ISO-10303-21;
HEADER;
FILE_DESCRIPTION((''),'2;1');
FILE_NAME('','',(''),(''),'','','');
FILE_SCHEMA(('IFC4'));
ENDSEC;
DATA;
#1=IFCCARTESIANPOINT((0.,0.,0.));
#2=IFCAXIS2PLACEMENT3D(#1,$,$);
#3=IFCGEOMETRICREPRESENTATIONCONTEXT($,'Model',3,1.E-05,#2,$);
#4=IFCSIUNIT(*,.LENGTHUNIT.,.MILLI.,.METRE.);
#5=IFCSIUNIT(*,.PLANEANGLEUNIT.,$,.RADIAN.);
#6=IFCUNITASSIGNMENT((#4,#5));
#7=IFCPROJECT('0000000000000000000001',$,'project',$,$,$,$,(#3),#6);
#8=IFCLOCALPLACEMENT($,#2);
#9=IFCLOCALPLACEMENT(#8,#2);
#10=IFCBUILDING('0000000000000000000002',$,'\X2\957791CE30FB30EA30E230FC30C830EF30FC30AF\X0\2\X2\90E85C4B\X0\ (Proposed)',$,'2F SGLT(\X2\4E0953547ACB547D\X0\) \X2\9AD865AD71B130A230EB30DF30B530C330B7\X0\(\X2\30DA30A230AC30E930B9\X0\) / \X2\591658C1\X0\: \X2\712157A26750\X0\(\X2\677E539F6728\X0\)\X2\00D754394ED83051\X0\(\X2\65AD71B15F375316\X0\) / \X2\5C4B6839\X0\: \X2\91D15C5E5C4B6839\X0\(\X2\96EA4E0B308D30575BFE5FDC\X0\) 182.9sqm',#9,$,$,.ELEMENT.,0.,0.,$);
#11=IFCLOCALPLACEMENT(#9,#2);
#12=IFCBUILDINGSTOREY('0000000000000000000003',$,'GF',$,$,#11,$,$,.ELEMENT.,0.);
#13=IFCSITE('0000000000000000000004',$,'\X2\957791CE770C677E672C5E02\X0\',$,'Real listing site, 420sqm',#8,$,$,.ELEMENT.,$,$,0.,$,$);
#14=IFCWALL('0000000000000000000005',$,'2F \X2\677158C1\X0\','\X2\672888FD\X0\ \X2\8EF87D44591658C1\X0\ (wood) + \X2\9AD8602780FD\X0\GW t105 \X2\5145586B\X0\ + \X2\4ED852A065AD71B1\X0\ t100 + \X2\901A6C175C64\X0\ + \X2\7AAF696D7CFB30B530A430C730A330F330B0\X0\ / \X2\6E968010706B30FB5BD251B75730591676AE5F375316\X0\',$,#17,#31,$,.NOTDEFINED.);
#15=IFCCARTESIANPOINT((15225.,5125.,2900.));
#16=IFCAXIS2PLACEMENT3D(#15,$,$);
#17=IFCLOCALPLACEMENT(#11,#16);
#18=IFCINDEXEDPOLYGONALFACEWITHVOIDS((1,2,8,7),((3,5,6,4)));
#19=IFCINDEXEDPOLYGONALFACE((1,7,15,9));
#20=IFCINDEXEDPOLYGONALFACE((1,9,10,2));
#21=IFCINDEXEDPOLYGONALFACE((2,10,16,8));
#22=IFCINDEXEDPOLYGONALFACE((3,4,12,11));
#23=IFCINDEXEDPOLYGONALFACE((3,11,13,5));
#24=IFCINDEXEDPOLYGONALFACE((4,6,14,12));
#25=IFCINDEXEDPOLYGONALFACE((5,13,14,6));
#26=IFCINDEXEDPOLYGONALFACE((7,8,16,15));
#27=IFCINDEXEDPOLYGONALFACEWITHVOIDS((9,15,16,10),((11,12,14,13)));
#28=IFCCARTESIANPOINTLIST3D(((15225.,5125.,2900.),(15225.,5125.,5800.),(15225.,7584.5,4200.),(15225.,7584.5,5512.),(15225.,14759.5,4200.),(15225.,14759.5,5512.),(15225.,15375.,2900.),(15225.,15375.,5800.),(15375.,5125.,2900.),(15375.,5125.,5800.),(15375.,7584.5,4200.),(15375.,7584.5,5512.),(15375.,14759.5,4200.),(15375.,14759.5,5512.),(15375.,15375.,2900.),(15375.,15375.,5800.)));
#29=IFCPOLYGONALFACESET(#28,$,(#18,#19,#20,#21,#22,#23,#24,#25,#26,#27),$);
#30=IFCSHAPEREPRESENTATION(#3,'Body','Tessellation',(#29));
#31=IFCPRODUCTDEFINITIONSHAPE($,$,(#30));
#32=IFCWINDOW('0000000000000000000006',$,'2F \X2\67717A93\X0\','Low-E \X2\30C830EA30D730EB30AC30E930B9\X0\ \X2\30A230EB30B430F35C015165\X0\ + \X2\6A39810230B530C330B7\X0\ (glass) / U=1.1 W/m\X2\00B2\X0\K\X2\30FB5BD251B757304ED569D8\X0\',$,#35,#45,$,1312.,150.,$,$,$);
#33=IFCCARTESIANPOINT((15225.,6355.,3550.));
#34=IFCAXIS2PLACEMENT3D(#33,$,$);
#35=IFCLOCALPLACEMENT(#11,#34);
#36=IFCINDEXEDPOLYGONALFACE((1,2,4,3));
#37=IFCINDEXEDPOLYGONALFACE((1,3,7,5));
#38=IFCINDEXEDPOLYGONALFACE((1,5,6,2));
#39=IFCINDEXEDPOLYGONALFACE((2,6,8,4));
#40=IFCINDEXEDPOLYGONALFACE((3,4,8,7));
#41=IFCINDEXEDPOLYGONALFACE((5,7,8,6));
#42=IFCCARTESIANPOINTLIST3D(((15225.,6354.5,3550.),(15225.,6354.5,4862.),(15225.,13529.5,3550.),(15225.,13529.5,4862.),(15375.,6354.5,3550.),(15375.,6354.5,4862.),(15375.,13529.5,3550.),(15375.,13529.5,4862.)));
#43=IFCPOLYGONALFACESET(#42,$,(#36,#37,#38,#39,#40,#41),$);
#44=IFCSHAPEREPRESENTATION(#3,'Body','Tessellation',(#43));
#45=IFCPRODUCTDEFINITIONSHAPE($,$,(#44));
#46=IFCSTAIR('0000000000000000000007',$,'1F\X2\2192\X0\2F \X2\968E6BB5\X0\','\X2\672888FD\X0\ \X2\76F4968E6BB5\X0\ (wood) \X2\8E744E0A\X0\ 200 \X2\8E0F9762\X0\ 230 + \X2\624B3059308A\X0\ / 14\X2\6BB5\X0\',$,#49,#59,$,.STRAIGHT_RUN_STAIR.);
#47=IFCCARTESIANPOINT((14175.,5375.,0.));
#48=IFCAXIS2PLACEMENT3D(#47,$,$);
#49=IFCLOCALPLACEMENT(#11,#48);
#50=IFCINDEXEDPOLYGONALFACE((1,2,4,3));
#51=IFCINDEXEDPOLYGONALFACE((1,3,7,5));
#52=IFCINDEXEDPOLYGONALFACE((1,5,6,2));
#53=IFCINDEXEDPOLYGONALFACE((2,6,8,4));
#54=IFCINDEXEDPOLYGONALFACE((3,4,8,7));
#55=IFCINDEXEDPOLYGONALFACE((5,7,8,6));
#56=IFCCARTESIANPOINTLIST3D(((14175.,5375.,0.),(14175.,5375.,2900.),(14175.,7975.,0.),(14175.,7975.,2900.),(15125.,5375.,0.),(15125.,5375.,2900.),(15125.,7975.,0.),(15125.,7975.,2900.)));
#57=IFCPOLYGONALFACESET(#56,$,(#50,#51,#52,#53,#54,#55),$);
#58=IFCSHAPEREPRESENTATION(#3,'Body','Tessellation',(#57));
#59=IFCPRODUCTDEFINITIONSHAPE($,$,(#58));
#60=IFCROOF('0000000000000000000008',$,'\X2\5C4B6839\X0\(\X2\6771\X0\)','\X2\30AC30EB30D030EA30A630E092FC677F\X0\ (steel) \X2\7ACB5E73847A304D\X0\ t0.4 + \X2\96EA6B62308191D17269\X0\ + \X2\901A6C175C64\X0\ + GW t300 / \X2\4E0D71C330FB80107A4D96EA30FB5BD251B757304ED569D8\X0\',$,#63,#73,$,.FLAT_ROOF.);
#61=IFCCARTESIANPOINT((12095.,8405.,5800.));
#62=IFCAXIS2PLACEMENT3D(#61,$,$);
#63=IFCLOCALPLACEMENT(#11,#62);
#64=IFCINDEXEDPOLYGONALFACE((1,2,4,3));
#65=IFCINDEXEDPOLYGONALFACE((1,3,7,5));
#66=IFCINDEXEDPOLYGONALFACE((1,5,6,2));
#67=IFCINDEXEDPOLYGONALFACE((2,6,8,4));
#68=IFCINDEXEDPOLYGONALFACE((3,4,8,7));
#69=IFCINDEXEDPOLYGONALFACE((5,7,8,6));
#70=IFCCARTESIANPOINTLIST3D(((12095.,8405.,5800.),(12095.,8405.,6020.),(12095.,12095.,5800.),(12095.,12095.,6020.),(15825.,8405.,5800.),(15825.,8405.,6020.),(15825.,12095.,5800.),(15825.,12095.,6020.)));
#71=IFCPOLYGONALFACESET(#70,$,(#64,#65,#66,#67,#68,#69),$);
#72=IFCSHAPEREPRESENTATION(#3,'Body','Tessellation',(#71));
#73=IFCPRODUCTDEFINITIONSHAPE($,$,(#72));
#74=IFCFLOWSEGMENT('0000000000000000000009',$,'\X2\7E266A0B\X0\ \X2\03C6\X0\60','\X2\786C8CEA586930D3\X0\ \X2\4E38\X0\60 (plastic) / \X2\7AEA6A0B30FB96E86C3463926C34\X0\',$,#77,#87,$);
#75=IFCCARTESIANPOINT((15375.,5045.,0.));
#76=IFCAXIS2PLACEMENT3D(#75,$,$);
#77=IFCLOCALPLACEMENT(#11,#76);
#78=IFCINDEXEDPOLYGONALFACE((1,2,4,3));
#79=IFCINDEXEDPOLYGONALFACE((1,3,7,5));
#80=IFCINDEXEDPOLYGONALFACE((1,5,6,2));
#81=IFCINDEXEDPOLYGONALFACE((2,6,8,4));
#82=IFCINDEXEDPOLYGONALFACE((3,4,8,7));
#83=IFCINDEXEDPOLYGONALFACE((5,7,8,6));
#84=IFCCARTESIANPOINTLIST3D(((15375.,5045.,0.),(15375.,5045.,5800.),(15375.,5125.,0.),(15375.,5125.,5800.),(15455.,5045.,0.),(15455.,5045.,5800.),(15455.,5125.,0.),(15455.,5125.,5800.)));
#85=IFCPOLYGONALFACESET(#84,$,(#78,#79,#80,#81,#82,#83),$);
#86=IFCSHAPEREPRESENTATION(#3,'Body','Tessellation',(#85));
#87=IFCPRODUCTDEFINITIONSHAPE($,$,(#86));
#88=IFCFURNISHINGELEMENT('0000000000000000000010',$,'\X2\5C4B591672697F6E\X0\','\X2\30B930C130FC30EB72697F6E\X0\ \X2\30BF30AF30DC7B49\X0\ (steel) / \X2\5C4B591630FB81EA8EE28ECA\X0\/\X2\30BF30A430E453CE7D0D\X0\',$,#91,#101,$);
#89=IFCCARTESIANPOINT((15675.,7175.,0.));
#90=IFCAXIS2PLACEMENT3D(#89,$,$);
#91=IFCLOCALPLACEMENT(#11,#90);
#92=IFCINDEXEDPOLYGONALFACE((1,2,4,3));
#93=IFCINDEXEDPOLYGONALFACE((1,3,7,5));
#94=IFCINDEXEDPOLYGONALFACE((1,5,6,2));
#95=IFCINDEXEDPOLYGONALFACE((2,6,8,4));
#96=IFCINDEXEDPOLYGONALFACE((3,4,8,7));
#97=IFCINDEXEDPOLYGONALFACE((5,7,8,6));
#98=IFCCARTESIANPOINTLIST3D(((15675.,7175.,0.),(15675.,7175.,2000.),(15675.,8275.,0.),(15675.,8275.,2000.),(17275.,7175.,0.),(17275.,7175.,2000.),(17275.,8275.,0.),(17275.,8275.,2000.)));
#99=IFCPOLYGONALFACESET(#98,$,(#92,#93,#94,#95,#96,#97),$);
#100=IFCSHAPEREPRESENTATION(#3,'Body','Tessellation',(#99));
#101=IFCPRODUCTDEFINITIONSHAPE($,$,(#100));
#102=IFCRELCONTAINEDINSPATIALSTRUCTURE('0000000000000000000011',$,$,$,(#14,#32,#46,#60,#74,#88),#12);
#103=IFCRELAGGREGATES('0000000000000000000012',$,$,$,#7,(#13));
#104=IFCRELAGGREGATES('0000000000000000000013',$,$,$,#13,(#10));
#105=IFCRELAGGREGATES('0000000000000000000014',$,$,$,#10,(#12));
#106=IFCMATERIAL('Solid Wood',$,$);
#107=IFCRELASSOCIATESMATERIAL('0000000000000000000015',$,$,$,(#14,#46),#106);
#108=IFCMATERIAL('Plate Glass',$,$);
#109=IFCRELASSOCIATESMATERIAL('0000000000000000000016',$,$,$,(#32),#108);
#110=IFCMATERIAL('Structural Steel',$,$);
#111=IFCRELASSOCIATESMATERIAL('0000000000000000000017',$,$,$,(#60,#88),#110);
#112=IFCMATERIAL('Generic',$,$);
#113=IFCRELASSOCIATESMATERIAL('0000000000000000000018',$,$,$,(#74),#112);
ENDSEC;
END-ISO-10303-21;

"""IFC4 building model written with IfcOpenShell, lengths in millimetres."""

from ifc_helpers import new_model, si_unit, frame, frame_2d, origin, place, context, project, spatial, rectangle, extrude, material, element, fill, save


model = new_model("IFC4")

# Units and contexts
model_context = context("Model", 3, precision=1e-05, world=origin())
ifc_project = project(units=[si_unit("LENGTHUNIT", "METRE", prefix="MILLI"), si_unit("PLANEANGLEUNIT", "RADIAN")], contexts=[model_context])

# Site, building, storey
site_placement = place(None, origin())
site = spatial("IfcSite", under=ifc_project, at=site_placement, Name="長野県松本市", ObjectType="Real listing site, 420sqm", CompositionType="ELEMENT", RefElevation=0.0)
building_placement = place(site_placement, origin())
building = spatial("IfcBuilding", under=site, at=building_placement, Name="長野・リモートワーク2部屋 (Proposed)", ObjectType="2F SGLT(三協立命) 高断熱アルミサッシ(ペアガラス) / 外壁: 無垢材(松原木)×吹付け(断熱強化) / 屋根: 金属屋根(雪下ろし対応) 182.9sqm", CompositionType="ELEMENT", ElevationOfRefHeight=0.0, ElevationOfTerrain=0.0)
storey_placement = place(building_placement, origin())
storey = spatial("IfcBuildingStorey", under=building, at=storey_placement, Name="GF", CompositionType="ELEMENT", Elevation=0.0)

# Shared definitions
ifc_material_1 = material(Name="Solid Wood")

# Wall, opening, window
ifc_material_2 = material(Name="Plate Glass")
wall_1_placement = place(storey_placement, frame((15225.0, 5125.0, 2900.0)))
wall_1 = element("IfcWall", 1, at=wall_1_placement, inside=storey, material=ifc_material_1, Name="2F 東壁", Description="木製 軸組外壁 (wood) + 高性能GW t105 充填 + 付加断熱 t100 + 通気層 + 窯業系サイディング / 準耐火・寒冷地外皮強化", PredefinedType="NOTDEFINED", context=model_context, shape_type="SweptSolid", body=[
    extrude(rectangle(XDim=150.0, YDim=10250.0, at=frame_2d((75.0, 5125.0))), frame((15225.0, 5125.0, 2900.0)), (0.0, 0.0, 1.0), 2900.0),
])
opening_1_placement = place(storey_placement, frame((15225.0, 6355.0, 3550.0)))
opening_1 = element("IfcOpeningElement", 2, at=opening_1_placement, cuts=wall_1, PredefinedType="NOTDEFINED", context=model_context, shape_type="SweptSolid", body=[
    extrude(rectangle(XDim=150.0, YDim=7175.0, at=frame_2d((75.0, 3587.0))), frame((15225.0, 6355.0, 3550.0)), (0.0, 0.0, 1.0), 1312.0),
])
window_1_placement = place(storey_placement, frame((15225.0, 6355.0, 3550.0)))
window_1 = element("IfcWindow", 3, at=window_1_placement, inside=storey, material=ifc_material_2, Name="2F 東窓", Description="Low-E トリプルガラス アルゴン封入 + 樹脂サッシ (glass) / U=1.1 W/m²K・寒冷地仕様", OverallHeight=1312.0, OverallWidth=150.0, context=model_context, shape_type="SweptSolid", body=[
    extrude(rectangle(XDim=150.0, YDim=7175.0, at=frame_2d((75.0, 3587.0))), frame((15225.0, 6355.0, 3550.0)), (0.0, 0.0, 1.0), 1312.0),
])
fill(opening_1, window_1)

# Stair
stair_placement = place(storey_placement, frame((14175.0, 5375.0, 0.0)))
element("IfcStair", 4, at=stair_placement, inside=storey, material=ifc_material_1, Name="1F→2F 階段", Description="木製 直階段 (wood) 蹴上 200 踏面 230 + 手すり / 14段", PredefinedType="STRAIGHT_RUN_STAIR", context=model_context, shape_type="SweptSolid", body=[
    extrude(rectangle(XDim=950.0, YDim=2600.0, at=frame_2d((475.0, 1300.0))), frame((14175.0, 5375.0, 0.0)), (0.0, 0.0, 1.0), 2900.0),
])

# Roof
ifc_material_3 = material(Name="Structural Steel")
roof_placement = place(storey_placement, frame((12095.0, 8405.0, 5800.0)))
element("IfcRoof", 5, at=roof_placement, inside=storey, material=ifc_material_3, Name="屋根(東)", Description="ガルバリウム鋼板 (steel) 立平葺き t0.4 + 雪止め金物 + 通気層 + GW t300 / 不燃・耐積雪・寒冷地仕様", PredefinedType="FLAT_ROOF", context=model_context, shape_type="SweptSolid", body=[
    extrude(rectangle(XDim=3730.0, YDim=3690.0, at=frame_2d((1865.0, 1845.0))), frame((12095.0, 8405.0, 5800.0)), (0.0, 0.0, 1.0), 220.0),
])

# Flow segment
ifc_material_4 = material(Name="Generic")
flow_segment_placement = place(storey_placement, frame((15375.0, 5045.0, 0.0)))
element("IfcFlowSegment", 6, at=flow_segment_placement, inside=storey, material=ifc_material_4, Name="縦樋 φ60", Description="硬質塩ビ 丸60 (plastic) / 竪樋・雨水排水", context=model_context, shape_type="SweptSolid", body=[
    extrude(rectangle(XDim=80.0, YDim=80.0, at=frame_2d((40.0, 40.0))), frame((15375.0, 5045.0, 0.0)), (0.0, 0.0, 1.0), 5800.0),
])

# Furnishing element
furnishing_placement = place(storey_placement, frame((15675.0, 7175.0, 0.0)))
element("IfcFurnishingElement", 7, at=furnishing_placement, inside=storey, material=ifc_material_3, Name="屋外物置", Description="スチール物置 タクボ等 (steel) / 屋外・自転車/タイヤ収納", context=model_context, shape_type="SweptSolid", body=[
    extrude(rectangle(XDim=1600.0, YDim=1100.0, at=frame_2d((800.0, 550.0))), frame((15675.0, 7175.0, 0.0)), (0.0, 0.0, 1.0), 2000.0),
])

save(model, "model.ifc")
